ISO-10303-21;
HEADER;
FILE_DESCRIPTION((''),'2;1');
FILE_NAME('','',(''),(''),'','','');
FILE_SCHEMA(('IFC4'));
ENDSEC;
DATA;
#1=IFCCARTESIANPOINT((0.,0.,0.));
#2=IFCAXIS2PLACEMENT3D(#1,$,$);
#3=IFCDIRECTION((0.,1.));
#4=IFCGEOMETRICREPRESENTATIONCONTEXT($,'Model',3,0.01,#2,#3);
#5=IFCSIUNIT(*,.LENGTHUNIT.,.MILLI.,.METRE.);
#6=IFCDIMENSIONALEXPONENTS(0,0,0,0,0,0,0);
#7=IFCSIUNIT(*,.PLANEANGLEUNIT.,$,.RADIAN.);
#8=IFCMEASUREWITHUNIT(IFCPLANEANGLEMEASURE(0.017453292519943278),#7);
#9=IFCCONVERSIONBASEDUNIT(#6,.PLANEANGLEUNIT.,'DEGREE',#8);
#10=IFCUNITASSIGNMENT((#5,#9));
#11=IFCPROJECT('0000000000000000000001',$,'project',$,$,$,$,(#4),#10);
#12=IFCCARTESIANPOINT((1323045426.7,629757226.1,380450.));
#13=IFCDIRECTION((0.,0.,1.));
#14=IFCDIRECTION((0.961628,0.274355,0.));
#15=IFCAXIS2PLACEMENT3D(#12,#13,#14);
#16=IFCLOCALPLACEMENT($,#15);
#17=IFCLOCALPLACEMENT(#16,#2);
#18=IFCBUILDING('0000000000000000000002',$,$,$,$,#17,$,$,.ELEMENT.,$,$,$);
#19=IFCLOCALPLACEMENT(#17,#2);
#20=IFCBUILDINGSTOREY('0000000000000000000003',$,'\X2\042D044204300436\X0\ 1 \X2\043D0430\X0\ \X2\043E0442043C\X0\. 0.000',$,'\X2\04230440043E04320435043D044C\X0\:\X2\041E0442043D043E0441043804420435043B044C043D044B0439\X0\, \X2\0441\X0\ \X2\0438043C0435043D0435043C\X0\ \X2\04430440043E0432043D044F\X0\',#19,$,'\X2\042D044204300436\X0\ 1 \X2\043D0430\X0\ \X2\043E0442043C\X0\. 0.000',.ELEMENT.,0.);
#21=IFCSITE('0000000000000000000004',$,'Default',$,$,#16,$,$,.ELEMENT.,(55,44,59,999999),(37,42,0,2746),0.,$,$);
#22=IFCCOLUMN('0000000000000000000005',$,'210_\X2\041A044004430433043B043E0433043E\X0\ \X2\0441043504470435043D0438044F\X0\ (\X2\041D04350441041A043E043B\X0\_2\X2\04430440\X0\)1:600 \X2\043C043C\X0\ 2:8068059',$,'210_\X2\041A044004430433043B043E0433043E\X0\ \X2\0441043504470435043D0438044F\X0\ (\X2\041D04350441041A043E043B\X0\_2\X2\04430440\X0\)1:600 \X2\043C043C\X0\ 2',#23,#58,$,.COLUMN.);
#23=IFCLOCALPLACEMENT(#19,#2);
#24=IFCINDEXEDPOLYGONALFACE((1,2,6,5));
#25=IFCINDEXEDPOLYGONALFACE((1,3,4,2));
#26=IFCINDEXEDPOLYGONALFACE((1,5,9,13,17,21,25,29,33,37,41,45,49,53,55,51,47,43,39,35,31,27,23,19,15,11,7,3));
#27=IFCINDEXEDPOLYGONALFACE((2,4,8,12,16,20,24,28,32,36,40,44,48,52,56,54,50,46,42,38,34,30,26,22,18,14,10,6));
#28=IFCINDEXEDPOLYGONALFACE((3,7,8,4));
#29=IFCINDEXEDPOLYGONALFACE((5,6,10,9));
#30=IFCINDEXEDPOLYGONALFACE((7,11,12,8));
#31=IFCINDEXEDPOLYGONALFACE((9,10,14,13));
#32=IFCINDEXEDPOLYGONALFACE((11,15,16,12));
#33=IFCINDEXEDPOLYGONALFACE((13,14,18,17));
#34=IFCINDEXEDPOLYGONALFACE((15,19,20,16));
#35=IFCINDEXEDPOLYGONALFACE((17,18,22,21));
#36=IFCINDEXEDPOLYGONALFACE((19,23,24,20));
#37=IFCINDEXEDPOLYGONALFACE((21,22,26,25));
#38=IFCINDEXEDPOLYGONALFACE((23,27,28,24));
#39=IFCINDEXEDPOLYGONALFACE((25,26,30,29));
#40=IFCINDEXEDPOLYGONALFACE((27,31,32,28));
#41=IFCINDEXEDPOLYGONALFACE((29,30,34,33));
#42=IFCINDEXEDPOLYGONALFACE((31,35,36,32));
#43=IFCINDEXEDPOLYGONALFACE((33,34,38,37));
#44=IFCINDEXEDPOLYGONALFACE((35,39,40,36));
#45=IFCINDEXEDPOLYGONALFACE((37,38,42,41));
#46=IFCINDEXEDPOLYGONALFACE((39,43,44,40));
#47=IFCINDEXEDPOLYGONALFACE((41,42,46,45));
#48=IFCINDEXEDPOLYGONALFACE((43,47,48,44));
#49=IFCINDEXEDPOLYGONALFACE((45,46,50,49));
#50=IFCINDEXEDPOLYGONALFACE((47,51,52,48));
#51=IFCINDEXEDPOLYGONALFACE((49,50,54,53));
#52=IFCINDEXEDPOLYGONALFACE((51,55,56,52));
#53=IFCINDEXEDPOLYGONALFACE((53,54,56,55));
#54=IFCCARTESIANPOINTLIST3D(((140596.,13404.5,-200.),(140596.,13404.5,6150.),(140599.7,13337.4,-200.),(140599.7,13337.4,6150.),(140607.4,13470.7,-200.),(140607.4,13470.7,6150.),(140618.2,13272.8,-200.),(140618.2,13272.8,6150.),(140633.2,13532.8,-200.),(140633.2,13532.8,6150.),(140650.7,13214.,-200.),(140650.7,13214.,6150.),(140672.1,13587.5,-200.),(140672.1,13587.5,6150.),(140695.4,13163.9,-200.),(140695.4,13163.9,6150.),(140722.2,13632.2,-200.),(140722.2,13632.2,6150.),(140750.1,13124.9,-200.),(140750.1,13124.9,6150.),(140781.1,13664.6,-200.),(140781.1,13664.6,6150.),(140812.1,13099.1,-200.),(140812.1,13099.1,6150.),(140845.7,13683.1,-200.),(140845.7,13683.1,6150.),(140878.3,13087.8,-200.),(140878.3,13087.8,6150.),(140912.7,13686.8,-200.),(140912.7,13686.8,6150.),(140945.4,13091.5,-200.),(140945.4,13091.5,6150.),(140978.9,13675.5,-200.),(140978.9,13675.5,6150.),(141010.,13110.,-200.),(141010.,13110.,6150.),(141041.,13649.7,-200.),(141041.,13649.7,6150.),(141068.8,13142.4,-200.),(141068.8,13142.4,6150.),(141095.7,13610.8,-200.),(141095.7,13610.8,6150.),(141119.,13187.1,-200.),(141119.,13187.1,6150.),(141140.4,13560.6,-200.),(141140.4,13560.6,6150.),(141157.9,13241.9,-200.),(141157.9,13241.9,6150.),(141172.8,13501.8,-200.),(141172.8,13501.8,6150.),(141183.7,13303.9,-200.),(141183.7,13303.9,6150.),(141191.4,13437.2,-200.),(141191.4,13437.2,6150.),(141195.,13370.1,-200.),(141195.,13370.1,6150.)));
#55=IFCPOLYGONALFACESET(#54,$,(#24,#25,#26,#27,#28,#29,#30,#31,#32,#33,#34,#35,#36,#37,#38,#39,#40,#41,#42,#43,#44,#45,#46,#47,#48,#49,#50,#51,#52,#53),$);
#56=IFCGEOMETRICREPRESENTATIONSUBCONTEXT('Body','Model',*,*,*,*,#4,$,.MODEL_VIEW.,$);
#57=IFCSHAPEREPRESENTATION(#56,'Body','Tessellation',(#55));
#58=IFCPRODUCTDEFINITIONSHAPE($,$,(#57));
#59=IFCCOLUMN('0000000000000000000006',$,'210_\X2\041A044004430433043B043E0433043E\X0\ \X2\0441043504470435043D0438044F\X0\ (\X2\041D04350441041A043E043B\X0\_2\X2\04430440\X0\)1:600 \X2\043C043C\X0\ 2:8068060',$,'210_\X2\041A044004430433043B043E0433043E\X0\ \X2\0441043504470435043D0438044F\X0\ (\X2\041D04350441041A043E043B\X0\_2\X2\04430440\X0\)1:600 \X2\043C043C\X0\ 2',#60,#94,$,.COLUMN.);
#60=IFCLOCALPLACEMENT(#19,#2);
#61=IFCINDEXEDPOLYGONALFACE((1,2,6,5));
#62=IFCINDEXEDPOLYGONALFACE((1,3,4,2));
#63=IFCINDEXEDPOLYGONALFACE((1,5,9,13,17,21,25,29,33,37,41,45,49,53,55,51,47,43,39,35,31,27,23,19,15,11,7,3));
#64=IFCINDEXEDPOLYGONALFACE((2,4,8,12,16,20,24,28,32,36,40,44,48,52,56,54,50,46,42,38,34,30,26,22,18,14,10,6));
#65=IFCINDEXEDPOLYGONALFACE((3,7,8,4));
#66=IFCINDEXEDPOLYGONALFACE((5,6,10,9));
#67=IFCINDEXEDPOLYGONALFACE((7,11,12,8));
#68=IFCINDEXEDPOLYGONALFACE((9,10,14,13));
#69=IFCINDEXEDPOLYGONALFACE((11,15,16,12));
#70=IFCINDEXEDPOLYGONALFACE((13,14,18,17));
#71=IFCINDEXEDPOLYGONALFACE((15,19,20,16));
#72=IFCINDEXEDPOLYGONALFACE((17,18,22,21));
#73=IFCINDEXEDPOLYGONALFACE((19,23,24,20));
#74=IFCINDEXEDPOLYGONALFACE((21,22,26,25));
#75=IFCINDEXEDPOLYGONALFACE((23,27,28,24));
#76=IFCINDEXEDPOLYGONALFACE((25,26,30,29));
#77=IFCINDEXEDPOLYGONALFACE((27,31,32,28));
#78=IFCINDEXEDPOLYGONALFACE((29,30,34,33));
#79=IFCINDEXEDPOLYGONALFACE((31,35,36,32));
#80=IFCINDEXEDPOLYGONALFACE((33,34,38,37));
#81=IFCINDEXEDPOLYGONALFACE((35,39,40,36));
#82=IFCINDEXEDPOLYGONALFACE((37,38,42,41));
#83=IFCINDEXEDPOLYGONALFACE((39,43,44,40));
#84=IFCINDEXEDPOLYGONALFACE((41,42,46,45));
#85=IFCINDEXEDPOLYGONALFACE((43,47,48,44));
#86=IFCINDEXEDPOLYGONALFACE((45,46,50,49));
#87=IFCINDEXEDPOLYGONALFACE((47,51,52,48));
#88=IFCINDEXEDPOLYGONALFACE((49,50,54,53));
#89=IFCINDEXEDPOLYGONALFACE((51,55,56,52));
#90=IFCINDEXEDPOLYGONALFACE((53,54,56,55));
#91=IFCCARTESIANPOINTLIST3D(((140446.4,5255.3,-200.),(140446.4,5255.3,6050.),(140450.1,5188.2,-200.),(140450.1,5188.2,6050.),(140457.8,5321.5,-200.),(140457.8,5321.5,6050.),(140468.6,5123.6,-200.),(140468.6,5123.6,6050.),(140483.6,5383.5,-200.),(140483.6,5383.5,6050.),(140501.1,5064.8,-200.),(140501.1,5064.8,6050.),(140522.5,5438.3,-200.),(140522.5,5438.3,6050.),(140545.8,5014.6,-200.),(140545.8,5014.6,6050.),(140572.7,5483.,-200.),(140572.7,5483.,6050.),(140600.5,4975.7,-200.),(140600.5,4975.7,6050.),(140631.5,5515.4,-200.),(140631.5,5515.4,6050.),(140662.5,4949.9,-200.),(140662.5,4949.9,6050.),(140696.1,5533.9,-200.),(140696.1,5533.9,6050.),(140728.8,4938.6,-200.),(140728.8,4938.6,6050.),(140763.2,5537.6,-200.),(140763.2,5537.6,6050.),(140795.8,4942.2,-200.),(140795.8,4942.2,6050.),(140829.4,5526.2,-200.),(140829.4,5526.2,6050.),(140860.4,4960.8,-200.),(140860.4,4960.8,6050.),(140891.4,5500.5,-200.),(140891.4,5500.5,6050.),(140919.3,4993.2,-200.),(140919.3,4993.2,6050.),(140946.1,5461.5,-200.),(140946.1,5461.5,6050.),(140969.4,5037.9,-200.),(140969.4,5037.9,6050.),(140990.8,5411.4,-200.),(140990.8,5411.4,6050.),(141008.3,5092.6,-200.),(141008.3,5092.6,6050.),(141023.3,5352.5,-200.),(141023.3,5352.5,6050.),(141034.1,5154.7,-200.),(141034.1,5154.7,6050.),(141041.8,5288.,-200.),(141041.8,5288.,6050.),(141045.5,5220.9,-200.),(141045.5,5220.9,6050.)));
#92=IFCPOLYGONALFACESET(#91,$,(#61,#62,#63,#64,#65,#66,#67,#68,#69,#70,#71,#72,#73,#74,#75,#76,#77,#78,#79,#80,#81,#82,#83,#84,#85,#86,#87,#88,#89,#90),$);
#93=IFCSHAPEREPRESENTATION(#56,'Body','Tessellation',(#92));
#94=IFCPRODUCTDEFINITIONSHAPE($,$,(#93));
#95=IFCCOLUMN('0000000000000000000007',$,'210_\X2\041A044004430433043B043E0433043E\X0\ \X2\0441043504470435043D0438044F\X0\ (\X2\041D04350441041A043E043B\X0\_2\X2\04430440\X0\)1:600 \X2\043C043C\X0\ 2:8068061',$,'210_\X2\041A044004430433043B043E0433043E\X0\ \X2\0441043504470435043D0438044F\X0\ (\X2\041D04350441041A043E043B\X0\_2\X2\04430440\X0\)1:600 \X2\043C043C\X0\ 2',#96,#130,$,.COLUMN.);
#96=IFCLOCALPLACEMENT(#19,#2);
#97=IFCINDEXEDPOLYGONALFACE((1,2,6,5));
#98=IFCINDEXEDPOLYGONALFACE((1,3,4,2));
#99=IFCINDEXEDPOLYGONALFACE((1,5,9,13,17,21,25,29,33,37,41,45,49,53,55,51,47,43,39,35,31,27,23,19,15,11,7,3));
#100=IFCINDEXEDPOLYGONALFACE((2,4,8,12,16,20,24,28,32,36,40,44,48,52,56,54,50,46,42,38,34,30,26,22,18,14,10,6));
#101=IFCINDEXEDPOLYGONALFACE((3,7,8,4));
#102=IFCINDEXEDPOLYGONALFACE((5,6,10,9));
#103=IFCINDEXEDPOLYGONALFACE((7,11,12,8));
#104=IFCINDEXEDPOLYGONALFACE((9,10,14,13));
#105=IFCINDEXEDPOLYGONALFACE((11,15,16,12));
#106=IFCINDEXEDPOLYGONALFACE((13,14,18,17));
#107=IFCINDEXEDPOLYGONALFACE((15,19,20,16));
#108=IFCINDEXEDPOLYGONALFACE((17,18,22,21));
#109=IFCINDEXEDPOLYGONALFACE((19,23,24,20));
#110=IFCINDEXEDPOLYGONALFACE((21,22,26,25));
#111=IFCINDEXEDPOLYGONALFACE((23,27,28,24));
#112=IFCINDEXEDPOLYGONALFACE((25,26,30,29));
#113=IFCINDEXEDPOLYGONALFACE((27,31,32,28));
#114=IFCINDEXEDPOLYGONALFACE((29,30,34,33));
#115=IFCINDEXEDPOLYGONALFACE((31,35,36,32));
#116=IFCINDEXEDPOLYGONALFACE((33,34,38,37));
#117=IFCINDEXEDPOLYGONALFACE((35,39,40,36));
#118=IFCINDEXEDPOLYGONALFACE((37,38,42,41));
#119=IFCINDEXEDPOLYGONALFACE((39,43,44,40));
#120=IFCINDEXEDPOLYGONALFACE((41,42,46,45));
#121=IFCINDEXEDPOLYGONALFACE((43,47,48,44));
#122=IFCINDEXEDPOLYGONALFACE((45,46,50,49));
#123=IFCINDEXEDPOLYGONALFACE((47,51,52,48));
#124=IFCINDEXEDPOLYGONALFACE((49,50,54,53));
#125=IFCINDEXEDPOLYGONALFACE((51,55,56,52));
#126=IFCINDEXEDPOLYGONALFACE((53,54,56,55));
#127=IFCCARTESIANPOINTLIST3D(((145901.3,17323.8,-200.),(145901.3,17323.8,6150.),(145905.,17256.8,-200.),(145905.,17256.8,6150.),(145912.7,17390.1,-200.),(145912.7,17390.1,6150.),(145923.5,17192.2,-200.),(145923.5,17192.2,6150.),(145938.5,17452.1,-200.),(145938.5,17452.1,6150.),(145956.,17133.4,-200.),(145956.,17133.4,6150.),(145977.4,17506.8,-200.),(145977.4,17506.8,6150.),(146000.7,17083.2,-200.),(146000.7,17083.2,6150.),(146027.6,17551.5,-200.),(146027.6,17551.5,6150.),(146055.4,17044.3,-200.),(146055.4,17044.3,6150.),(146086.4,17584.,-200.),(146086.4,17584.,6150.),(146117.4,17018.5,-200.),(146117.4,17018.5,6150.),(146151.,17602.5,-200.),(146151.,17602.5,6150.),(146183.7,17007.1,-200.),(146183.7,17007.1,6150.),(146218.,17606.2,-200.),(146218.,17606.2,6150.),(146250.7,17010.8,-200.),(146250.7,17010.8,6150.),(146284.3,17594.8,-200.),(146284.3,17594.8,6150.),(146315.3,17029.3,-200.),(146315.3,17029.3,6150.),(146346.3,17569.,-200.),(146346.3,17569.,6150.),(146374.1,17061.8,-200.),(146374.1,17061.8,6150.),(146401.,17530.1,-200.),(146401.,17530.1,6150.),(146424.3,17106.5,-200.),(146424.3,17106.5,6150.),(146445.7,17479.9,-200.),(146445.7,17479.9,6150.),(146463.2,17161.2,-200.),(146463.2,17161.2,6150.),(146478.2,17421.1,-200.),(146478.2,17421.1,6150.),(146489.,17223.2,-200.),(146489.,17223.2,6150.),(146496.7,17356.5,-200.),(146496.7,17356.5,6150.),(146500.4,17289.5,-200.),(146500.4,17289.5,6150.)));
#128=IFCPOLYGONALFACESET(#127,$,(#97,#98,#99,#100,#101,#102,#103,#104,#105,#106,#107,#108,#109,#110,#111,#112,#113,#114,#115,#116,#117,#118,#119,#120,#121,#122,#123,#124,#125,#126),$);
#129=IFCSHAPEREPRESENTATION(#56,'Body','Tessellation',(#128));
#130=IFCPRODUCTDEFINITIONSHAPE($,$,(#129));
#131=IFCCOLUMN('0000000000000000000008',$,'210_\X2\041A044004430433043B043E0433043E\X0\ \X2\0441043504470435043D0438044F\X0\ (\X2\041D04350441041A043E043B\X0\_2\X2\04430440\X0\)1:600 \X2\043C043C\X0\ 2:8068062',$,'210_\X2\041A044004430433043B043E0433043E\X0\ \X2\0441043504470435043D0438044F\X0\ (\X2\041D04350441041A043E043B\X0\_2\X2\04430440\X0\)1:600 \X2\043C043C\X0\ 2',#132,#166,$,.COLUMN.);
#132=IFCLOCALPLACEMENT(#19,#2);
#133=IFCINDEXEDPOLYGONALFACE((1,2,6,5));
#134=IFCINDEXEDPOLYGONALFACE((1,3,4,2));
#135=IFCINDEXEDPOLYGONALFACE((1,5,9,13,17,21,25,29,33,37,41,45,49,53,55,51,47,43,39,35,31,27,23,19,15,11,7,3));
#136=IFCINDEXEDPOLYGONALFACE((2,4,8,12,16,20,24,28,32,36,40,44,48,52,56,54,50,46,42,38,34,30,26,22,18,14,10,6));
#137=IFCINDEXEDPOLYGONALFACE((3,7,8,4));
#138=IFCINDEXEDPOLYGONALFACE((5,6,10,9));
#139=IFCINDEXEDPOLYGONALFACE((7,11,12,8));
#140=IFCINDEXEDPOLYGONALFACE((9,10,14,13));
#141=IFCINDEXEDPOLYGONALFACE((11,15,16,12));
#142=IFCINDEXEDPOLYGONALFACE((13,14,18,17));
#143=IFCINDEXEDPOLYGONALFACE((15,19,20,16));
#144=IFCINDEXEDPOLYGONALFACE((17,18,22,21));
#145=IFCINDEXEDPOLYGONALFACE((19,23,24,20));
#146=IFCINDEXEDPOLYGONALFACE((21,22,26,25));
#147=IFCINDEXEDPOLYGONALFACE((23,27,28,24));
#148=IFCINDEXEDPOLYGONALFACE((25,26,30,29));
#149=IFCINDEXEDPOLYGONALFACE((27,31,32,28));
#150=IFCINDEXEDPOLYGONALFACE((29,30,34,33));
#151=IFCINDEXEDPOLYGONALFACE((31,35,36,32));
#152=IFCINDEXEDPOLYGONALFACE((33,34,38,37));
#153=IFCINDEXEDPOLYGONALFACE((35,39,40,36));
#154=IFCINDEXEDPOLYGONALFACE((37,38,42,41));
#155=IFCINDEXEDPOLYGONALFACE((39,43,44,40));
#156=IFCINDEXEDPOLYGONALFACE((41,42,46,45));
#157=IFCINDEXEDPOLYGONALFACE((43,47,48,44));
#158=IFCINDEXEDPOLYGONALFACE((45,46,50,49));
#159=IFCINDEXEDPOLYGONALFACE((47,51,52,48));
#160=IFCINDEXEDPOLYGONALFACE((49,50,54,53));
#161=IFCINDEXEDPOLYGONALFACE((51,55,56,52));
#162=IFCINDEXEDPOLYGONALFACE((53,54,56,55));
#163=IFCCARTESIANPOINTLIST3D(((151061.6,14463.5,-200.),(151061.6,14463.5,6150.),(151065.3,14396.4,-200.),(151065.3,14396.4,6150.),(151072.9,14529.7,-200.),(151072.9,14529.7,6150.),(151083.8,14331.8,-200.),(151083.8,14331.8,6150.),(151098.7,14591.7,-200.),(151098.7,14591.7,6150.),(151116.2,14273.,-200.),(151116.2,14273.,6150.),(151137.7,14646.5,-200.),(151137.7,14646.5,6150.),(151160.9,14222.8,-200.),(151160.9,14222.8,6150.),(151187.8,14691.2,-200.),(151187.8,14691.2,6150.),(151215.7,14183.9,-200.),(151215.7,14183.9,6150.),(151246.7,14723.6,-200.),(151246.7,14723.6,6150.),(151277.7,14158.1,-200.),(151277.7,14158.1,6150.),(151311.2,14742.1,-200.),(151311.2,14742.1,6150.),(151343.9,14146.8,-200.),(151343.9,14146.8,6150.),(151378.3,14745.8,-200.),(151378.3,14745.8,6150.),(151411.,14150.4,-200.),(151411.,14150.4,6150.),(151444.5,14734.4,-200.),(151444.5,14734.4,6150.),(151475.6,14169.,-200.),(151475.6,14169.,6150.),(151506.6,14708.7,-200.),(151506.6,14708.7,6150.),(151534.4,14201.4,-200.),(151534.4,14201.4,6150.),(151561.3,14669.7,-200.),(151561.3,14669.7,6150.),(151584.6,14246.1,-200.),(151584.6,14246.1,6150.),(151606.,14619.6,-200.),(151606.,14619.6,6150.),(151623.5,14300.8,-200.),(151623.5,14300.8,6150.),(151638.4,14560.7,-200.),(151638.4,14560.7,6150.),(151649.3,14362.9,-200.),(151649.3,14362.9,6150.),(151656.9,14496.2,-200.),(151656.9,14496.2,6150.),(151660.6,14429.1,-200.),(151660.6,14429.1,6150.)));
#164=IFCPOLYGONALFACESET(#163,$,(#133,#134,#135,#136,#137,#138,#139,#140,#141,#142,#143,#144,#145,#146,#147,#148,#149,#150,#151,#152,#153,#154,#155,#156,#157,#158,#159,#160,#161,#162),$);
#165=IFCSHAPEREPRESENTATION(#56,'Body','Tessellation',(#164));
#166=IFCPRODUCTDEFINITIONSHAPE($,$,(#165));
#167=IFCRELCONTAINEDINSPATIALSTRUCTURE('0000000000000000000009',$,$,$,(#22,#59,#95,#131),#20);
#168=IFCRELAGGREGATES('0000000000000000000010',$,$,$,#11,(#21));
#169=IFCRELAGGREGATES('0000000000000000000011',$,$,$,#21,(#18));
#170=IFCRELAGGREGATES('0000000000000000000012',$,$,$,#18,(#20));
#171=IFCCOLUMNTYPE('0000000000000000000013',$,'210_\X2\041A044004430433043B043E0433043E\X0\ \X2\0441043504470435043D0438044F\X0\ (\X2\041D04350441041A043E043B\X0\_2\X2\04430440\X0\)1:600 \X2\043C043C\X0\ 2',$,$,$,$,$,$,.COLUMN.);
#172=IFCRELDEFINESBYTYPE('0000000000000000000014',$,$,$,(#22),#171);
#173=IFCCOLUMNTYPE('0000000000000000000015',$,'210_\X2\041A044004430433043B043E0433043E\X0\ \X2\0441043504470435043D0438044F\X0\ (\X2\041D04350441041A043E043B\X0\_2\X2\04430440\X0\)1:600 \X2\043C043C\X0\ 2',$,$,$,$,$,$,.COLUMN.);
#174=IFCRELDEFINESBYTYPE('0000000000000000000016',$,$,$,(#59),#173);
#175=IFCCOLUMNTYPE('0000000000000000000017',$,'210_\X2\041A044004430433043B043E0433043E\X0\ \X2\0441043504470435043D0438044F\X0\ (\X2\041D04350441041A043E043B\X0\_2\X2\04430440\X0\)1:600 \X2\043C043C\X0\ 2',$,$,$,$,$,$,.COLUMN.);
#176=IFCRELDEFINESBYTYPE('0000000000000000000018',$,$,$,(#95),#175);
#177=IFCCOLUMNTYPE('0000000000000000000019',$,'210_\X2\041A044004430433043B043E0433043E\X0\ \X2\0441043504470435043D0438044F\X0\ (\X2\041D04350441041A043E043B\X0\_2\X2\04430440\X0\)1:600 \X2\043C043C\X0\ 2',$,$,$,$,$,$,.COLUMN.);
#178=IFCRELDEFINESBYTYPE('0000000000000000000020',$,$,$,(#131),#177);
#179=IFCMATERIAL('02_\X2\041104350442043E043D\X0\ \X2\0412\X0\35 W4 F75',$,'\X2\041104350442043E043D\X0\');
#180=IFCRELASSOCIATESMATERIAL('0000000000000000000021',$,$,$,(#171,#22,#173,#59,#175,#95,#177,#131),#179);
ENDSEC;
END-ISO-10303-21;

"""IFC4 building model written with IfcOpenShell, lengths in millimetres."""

from ifc_helpers import new_model, entity, si_unit, converted_unit, direction, frame, origin, place, context, subcontext, project, spatial, arc, indexed_curve, outline, extrude, source, transform, mapped, material, type_object, type_shapes, element, save


model = new_model("IFC4")

# Units and contexts
model_context = context("Model", 3, precision=0.01, world=origin(), true_north=direction((0.0, 1.0)))
body_context = subcontext(model_context, "Body", "Model", "MODEL_VIEW")
ifc_project = project(units=[si_unit("LENGTHUNIT", "METRE", prefix="MILLI"), converted_unit("PLANEANGLEUNIT", "DEGREE", entity("IfcPlaneAngleMeasure", 0.017453292519943278), si_unit("PLANEANGLEUNIT", "RADIAN"), dimensions=[0, 0, 0, 0, 0, 0, 0])], contexts=[model_context])

# Site, building, storey
site_placement = place(None, frame((1323045426.7, 629757226.1, 380450.0), z_axis=(0.0, 0.0, 1.0), x_axis=(0.961628, 0.274355, 0.0)))
site = spatial("IfcSite", under=ifc_project, at=site_placement, Name="Default", CompositionType="ELEMENT", RefLatitude=(55, 44, 59, 999999), RefLongitude=(37, 42, 0, 2746), RefElevation=0.0)
building_placement = place(site_placement, origin())
building = spatial("IfcBuilding", under=site, at=building_placement, CompositionType="ELEMENT")
storey_placement = place(building_placement, origin())
storey = spatial("IfcBuildingStorey", under=building, at=storey_placement, Name="Этаж 1 на отм. 0.000", ObjectType="Уровень:Относительный, с именем уровня", LongName="Этаж 1 на отм. 0.000", CompositionType="ELEMENT", Elevation=0.0)

# Columns
ifc_material = material(Name="02_Бетон В35 W4 F75", Category="Бетон")
column_type_1 = type_object("IfcColumnType", Name="210_Круглого сечения (НесКол_2ур)1:600 мм 2", PredefinedType="COLUMN", material=ifc_material)
shared_shape_1 = source(origin(), body_context, "Body", "SweptSolid", [
    extrude(outline(indexed_curve([(-300.0, 0.0), (0.0, -300.0), (300.0, 0.0), (0.0, 300.0)], segments=[arc(1, 2, 3), arc(3, 4, 1)], self_intersect=False)), frame((140895.5, 13387.3, -200.0), z_axis=(0.0, 0.0, 1.0), x_axis=(0.87462, -0.48481, 0.0)), (0.0, 0.0, 1.0), 6350.0),
])
type_shapes(column_type_1, [shared_shape_1])
column_1_placement = place(storey_placement, origin())
element("IfcColumn", 1, at=column_1_placement, inside=storey, type_object=column_type_1, material=ifc_material, Name="210_Круглого сечения (НесКол_2ур)1:600 мм 2:8068059", ObjectType="210_Круглого сечения (НесКол_2ур)1:600 мм 2", PredefinedType="COLUMN", context=body_context, shape_type="MappedRepresentation", body=[
    mapped(shared_shape_1, transform((0.0, 0.0, 0.0), scale=1.0)),
])
column_type_2 = type_object("IfcColumnType", Name="210_Круглого сечения (НесКол_2ур)1:600 мм 2", PredefinedType="COLUMN", material=ifc_material)
shared_shape_2 = source(origin(), body_context, "Body", "SweptSolid", [
    extrude(outline(indexed_curve([(-300.0, 0.0), (0.0, -300.0), (300.0, 0.0), (0.0, 300.0)], segments=[arc(1, 2, 3), arc(3, 4, 1)], self_intersect=False)), frame((140746.0, 5238.1, -200.0), z_axis=(0.0, 0.0, 1.0), x_axis=(0.87462, -0.48481, 0.0)), (0.0, 0.0, 1.0), 6250.0),
])
type_shapes(column_type_2, [shared_shape_2])
column_2_placement = place(storey_placement, origin())
element("IfcColumn", 2, at=column_2_placement, inside=storey, type_object=column_type_2, material=ifc_material, Name="210_Круглого сечения (НесКол_2ур)1:600 мм 2:8068060", ObjectType="210_Круглого сечения (НесКол_2ур)1:600 мм 2", PredefinedType="COLUMN", context=body_context, shape_type="MappedRepresentation", body=[
    mapped(shared_shape_2, transform((0.0, 0.0, 0.0), scale=1.0)),
])
column_type_3 = type_object("IfcColumnType", Name="210_Круглого сечения (НесКол_2ур)1:600 мм 2", PredefinedType="COLUMN", material=ifc_material)
shared_shape_3 = source(origin(), body_context, "Body", "SweptSolid", [
    extrude(outline(indexed_curve([(-300.0, 0.0), (0.0, -300.0), (300.0, 0.0), (0.0, 300.0)], segments=[arc(1, 2, 3), arc(3, 4, 1)], self_intersect=False)), frame((146200.9, 17306.6, -200.0), z_axis=(0.0, 0.0, 1.0), x_axis=(0.87462, -0.48481, 0.0)), (0.0, 0.0, 1.0), 6350.0),
])
type_shapes(column_type_3, [shared_shape_3])
column_3_placement = place(storey_placement, origin())
element("IfcColumn", 3, at=column_3_placement, inside=storey, type_object=column_type_3, material=ifc_material, Name="210_Круглого сечения (НесКол_2ур)1:600 мм 2:8068061", ObjectType="210_Круглого сечения (НесКол_2ур)1:600 мм 2", PredefinedType="COLUMN", context=body_context, shape_type="MappedRepresentation", body=[
    mapped(shared_shape_3, transform((0.0, 0.0, 0.0), scale=1.0)),
])
column_type_4 = type_object("IfcColumnType", Name="210_Круглого сечения (НесКол_2ур)1:600 мм 2", PredefinedType="COLUMN", material=ifc_material)
shared_shape_4 = source(origin(), body_context, "Body", "SweptSolid", [
    extrude(outline(indexed_curve([(-300.0, 0.0), (0.0, -300.0), (300.0, 0.0), (0.0, 300.0)], segments=[arc(1, 2, 3), arc(3, 4, 1)], self_intersect=False)), frame((151361.1, 14446.3, -200.0), z_axis=(0.0, 0.0, 1.0), x_axis=(0.87462, -0.48481, 0.0)), (0.0, 0.0, 1.0), 6350.0),
])
type_shapes(column_type_4, [shared_shape_4])
column_4_placement = place(storey_placement, origin())
element("IfcColumn", 4, at=column_4_placement, inside=storey, type_object=column_type_4, material=ifc_material, Name="210_Круглого сечения (НесКол_2ур)1:600 мм 2:8068062", ObjectType="210_Круглого сечения (НесКол_2ур)1:600 мм 2", PredefinedType="COLUMN", context=body_context, shape_type="MappedRepresentation", body=[
    mapped(shared_shape_4, transform((0.0, 0.0, 0.0), scale=1.0)),
])

save(model, "model.ifc")
